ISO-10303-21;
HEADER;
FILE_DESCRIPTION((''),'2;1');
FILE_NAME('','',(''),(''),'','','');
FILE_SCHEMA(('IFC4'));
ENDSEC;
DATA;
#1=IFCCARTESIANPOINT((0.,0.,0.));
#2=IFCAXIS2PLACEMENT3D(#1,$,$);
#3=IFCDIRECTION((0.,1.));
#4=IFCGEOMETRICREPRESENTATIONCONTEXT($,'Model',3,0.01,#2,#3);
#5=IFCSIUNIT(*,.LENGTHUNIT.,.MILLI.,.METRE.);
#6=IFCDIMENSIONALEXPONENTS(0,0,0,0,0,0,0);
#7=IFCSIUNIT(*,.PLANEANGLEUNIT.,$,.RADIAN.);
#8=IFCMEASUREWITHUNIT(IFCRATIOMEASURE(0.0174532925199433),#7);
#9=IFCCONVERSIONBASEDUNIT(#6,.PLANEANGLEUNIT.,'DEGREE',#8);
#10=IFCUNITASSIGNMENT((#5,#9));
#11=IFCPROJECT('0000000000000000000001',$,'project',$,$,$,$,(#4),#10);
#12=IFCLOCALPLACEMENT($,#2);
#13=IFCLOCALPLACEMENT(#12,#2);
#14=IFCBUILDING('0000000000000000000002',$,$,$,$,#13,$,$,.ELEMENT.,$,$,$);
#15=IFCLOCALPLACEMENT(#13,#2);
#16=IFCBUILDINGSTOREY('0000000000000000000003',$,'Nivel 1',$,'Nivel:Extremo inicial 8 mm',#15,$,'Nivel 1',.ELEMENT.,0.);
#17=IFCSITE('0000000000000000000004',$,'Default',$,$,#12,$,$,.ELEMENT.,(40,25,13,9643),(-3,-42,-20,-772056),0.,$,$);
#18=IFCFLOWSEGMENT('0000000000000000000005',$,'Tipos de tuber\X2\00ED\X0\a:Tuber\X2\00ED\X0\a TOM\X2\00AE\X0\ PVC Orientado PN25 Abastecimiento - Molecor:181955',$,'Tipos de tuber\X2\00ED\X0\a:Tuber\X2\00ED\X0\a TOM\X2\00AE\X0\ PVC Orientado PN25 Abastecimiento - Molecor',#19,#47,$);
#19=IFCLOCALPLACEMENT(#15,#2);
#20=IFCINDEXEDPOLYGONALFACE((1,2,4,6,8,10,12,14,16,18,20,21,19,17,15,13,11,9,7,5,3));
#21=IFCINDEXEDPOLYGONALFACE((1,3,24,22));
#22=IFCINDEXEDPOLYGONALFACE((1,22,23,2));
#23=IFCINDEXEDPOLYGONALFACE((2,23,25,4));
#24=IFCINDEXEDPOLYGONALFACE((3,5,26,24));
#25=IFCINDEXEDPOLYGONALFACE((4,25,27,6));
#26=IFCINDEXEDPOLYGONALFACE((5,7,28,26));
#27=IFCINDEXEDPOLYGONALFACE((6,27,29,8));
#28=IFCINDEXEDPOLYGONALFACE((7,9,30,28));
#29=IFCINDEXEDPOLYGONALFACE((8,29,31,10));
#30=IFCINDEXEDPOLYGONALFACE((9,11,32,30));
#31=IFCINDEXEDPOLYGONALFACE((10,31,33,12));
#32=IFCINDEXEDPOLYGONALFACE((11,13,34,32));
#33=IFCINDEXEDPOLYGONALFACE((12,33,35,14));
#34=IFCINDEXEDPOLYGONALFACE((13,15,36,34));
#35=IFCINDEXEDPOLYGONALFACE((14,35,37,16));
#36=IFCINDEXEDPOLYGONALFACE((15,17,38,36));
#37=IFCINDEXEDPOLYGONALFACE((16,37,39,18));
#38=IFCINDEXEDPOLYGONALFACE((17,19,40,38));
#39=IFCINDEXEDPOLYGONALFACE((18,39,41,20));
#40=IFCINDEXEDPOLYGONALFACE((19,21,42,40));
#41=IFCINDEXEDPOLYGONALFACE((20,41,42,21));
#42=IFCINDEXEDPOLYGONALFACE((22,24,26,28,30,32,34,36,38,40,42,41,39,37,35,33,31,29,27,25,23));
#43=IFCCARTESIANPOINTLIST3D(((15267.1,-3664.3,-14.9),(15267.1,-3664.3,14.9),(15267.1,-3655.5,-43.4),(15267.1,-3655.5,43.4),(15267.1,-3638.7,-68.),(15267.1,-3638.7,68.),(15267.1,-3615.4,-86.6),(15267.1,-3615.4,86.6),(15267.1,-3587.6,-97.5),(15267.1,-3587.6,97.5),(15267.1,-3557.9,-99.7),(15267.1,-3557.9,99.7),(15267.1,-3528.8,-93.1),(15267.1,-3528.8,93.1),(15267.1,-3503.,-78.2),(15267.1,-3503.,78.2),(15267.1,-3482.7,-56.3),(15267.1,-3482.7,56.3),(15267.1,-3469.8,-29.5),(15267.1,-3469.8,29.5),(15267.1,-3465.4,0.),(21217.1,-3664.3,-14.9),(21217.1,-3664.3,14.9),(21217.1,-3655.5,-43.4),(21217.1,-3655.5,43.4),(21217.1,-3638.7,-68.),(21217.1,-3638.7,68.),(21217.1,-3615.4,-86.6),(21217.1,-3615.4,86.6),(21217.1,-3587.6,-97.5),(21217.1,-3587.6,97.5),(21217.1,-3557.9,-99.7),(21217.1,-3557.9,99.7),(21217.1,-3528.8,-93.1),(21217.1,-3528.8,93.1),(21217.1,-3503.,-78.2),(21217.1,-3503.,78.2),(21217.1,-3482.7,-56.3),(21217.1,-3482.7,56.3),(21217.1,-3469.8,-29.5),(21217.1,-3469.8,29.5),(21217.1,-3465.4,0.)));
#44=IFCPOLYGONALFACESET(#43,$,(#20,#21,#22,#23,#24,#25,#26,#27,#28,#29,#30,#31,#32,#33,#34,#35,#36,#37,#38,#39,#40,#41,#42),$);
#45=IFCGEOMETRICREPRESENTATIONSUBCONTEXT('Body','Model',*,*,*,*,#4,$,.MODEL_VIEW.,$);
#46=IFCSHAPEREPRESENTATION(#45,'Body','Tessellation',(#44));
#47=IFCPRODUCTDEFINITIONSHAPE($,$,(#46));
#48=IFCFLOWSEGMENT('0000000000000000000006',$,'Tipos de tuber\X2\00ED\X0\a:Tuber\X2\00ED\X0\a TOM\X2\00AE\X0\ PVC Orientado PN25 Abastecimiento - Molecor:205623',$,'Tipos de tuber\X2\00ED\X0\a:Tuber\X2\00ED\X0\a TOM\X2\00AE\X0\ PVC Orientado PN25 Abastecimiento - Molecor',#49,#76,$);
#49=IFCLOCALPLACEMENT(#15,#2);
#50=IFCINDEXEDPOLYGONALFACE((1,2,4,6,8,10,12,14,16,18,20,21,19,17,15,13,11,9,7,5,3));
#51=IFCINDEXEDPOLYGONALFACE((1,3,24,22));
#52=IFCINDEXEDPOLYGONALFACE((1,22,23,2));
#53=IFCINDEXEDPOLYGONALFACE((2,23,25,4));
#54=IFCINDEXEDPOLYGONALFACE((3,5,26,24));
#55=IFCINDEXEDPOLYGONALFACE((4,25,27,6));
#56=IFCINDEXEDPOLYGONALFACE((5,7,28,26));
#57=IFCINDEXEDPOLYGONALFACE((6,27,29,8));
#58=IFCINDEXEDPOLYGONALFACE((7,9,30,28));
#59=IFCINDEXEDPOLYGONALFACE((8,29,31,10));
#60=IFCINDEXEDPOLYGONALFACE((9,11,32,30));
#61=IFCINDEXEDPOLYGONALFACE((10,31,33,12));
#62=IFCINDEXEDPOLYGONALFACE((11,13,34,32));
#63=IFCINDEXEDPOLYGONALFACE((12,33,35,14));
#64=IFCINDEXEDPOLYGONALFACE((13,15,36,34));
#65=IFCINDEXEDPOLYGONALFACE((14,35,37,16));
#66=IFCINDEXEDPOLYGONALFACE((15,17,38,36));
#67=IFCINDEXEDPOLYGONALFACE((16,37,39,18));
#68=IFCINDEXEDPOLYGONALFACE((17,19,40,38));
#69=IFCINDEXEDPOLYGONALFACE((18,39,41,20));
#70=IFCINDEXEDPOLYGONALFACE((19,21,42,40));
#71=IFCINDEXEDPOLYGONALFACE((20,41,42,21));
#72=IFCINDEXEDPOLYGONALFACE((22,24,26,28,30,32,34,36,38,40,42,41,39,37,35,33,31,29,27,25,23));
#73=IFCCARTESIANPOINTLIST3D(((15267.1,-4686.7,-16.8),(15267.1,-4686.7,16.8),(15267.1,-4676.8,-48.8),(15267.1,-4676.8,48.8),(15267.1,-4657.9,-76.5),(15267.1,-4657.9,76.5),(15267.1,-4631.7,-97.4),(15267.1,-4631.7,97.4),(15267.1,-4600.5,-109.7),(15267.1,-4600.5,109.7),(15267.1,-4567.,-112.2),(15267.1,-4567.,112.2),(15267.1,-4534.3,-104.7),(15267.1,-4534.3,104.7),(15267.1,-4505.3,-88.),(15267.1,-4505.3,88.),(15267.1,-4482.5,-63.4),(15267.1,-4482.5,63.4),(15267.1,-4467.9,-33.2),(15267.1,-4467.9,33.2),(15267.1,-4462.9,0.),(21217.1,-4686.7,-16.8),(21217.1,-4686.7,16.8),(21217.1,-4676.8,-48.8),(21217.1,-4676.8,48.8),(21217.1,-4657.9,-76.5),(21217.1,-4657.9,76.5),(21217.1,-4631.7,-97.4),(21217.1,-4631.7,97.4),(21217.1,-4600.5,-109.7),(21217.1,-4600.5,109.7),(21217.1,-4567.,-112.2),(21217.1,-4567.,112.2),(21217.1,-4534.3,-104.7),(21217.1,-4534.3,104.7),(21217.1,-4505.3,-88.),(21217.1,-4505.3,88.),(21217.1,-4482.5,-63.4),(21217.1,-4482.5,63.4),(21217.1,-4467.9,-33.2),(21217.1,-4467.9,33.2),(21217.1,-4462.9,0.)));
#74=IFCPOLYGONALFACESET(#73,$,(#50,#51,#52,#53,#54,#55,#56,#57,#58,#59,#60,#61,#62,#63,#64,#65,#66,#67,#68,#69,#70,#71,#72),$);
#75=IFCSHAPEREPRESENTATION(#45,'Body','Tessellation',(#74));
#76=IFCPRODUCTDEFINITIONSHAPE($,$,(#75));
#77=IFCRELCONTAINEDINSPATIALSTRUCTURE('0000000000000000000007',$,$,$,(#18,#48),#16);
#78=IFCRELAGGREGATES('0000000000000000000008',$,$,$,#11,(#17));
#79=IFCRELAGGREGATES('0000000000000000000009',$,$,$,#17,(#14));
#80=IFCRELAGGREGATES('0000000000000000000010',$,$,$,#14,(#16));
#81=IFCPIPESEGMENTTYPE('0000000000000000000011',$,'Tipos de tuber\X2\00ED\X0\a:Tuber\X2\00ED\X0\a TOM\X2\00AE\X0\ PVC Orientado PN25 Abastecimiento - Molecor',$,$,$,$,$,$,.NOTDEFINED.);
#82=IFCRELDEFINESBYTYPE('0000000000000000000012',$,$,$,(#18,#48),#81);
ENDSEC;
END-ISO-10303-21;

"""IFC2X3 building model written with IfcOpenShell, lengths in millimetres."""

from ifc_helpers import new_model, entity, si_unit, converted_unit, direction, frame, frame_2d, origin, place, context, subcontext, project, spatial, circle, extrude, type_object, element, save


model = new_model("IFC2X3")

# Units and contexts
model_context = context("Model", 3, precision=0.01, world=origin(), true_north=direction((0.0, 1.0)))
body_context = subcontext(model_context, "Body", "Model", "MODEL_VIEW")
ifc_project = project(units=[si_unit("LENGTHUNIT", "METRE", prefix="MILLI"), converted_unit("PLANEANGLEUNIT", "DEGREE", entity("IfcRatioMeasure", 0.0174532925199433), si_unit("PLANEANGLEUNIT", "RADIAN"), dimensions=[0, 0, 0, 0, 0, 0, 0])], contexts=[model_context])

# Site, building, storey
site_placement = place(None, origin())
site = spatial("IfcSite", under=ifc_project, at=site_placement, Name="Default", CompositionType="ELEMENT", RefLatitude=(40, 25, 13, 9643), RefLongitude=(-3, -42, -20, -772056), RefElevation=0.0)
building_placement = place(site_placement, origin())
building = spatial("IfcBuilding", under=site, at=building_placement, CompositionType="ELEMENT")
storey_placement = place(building_placement, origin())
storey = spatial("IfcBuildingStorey", under=building, at=storey_placement, Name="Nivel 1", ObjectType="Nivel:Extremo inicial 8 mm", LongName="Nivel 1", CompositionType="ELEMENT", Elevation=0.0)

# Flow segments
pipe_segment_type = type_object("IfcPipeSegmentType", Name="Tipos de tubería:Tubería TOM® PVC Orientado PN25 Abastecimiento - Molecor", PredefinedType="NOTDEFINED")
flow_segment_1_placement = place(storey_placement, frame((15267.1, -3667.0, -101.6)))
element("IfcFlowSegment", 1, at=flow_segment_1_placement, inside=storey, type_object=pipe_segment_type, Name="Tipos de tubería:Tubería TOM® PVC Orientado PN25 Abastecimiento - Molecor:181955", ObjectType="Tipos de tubería:Tubería TOM® PVC Orientado PN25 Abastecimiento - Molecor", context=body_context, shape_type="SweptSolid", body=[
    extrude(circle(Radius=100.0, at=frame_2d((0.0, 0.0), x_axis=(1.0, 0.0))), frame((0.0, 101.6, 101.6), z_axis=(1.0, 0.0, 0.0), x_axis=(0.0, 1.0, 0.0)), (0.0, 0.0, 1.0), 5950.0),
])
flow_segment_2_placement = place(storey_placement, frame((15267.1, -4689.5, -114.1)))
element("IfcFlowSegment", 2, at=flow_segment_2_placement, inside=storey, type_object=pipe_segment_type, Name="Tipos de tubería:Tubería TOM® PVC Orientado PN25 Abastecimiento - Molecor:205623", ObjectType="Tipos de tubería:Tubería TOM® PVC Orientado PN25 Abastecimiento - Molecor", context=body_context, shape_type="SweptSolid", body=[
    extrude(circle(Radius=112.5, at=frame_2d((0.0, 0.0), x_axis=(1.0, 0.0))), frame((0.0, 114.1, 114.1), z_axis=(1.0, 0.0, 0.0), x_axis=(0.0, 1.0, 0.0)), (0.0, 0.0, 1.0), 5950.0),
])

save(model, "model.ifc")
